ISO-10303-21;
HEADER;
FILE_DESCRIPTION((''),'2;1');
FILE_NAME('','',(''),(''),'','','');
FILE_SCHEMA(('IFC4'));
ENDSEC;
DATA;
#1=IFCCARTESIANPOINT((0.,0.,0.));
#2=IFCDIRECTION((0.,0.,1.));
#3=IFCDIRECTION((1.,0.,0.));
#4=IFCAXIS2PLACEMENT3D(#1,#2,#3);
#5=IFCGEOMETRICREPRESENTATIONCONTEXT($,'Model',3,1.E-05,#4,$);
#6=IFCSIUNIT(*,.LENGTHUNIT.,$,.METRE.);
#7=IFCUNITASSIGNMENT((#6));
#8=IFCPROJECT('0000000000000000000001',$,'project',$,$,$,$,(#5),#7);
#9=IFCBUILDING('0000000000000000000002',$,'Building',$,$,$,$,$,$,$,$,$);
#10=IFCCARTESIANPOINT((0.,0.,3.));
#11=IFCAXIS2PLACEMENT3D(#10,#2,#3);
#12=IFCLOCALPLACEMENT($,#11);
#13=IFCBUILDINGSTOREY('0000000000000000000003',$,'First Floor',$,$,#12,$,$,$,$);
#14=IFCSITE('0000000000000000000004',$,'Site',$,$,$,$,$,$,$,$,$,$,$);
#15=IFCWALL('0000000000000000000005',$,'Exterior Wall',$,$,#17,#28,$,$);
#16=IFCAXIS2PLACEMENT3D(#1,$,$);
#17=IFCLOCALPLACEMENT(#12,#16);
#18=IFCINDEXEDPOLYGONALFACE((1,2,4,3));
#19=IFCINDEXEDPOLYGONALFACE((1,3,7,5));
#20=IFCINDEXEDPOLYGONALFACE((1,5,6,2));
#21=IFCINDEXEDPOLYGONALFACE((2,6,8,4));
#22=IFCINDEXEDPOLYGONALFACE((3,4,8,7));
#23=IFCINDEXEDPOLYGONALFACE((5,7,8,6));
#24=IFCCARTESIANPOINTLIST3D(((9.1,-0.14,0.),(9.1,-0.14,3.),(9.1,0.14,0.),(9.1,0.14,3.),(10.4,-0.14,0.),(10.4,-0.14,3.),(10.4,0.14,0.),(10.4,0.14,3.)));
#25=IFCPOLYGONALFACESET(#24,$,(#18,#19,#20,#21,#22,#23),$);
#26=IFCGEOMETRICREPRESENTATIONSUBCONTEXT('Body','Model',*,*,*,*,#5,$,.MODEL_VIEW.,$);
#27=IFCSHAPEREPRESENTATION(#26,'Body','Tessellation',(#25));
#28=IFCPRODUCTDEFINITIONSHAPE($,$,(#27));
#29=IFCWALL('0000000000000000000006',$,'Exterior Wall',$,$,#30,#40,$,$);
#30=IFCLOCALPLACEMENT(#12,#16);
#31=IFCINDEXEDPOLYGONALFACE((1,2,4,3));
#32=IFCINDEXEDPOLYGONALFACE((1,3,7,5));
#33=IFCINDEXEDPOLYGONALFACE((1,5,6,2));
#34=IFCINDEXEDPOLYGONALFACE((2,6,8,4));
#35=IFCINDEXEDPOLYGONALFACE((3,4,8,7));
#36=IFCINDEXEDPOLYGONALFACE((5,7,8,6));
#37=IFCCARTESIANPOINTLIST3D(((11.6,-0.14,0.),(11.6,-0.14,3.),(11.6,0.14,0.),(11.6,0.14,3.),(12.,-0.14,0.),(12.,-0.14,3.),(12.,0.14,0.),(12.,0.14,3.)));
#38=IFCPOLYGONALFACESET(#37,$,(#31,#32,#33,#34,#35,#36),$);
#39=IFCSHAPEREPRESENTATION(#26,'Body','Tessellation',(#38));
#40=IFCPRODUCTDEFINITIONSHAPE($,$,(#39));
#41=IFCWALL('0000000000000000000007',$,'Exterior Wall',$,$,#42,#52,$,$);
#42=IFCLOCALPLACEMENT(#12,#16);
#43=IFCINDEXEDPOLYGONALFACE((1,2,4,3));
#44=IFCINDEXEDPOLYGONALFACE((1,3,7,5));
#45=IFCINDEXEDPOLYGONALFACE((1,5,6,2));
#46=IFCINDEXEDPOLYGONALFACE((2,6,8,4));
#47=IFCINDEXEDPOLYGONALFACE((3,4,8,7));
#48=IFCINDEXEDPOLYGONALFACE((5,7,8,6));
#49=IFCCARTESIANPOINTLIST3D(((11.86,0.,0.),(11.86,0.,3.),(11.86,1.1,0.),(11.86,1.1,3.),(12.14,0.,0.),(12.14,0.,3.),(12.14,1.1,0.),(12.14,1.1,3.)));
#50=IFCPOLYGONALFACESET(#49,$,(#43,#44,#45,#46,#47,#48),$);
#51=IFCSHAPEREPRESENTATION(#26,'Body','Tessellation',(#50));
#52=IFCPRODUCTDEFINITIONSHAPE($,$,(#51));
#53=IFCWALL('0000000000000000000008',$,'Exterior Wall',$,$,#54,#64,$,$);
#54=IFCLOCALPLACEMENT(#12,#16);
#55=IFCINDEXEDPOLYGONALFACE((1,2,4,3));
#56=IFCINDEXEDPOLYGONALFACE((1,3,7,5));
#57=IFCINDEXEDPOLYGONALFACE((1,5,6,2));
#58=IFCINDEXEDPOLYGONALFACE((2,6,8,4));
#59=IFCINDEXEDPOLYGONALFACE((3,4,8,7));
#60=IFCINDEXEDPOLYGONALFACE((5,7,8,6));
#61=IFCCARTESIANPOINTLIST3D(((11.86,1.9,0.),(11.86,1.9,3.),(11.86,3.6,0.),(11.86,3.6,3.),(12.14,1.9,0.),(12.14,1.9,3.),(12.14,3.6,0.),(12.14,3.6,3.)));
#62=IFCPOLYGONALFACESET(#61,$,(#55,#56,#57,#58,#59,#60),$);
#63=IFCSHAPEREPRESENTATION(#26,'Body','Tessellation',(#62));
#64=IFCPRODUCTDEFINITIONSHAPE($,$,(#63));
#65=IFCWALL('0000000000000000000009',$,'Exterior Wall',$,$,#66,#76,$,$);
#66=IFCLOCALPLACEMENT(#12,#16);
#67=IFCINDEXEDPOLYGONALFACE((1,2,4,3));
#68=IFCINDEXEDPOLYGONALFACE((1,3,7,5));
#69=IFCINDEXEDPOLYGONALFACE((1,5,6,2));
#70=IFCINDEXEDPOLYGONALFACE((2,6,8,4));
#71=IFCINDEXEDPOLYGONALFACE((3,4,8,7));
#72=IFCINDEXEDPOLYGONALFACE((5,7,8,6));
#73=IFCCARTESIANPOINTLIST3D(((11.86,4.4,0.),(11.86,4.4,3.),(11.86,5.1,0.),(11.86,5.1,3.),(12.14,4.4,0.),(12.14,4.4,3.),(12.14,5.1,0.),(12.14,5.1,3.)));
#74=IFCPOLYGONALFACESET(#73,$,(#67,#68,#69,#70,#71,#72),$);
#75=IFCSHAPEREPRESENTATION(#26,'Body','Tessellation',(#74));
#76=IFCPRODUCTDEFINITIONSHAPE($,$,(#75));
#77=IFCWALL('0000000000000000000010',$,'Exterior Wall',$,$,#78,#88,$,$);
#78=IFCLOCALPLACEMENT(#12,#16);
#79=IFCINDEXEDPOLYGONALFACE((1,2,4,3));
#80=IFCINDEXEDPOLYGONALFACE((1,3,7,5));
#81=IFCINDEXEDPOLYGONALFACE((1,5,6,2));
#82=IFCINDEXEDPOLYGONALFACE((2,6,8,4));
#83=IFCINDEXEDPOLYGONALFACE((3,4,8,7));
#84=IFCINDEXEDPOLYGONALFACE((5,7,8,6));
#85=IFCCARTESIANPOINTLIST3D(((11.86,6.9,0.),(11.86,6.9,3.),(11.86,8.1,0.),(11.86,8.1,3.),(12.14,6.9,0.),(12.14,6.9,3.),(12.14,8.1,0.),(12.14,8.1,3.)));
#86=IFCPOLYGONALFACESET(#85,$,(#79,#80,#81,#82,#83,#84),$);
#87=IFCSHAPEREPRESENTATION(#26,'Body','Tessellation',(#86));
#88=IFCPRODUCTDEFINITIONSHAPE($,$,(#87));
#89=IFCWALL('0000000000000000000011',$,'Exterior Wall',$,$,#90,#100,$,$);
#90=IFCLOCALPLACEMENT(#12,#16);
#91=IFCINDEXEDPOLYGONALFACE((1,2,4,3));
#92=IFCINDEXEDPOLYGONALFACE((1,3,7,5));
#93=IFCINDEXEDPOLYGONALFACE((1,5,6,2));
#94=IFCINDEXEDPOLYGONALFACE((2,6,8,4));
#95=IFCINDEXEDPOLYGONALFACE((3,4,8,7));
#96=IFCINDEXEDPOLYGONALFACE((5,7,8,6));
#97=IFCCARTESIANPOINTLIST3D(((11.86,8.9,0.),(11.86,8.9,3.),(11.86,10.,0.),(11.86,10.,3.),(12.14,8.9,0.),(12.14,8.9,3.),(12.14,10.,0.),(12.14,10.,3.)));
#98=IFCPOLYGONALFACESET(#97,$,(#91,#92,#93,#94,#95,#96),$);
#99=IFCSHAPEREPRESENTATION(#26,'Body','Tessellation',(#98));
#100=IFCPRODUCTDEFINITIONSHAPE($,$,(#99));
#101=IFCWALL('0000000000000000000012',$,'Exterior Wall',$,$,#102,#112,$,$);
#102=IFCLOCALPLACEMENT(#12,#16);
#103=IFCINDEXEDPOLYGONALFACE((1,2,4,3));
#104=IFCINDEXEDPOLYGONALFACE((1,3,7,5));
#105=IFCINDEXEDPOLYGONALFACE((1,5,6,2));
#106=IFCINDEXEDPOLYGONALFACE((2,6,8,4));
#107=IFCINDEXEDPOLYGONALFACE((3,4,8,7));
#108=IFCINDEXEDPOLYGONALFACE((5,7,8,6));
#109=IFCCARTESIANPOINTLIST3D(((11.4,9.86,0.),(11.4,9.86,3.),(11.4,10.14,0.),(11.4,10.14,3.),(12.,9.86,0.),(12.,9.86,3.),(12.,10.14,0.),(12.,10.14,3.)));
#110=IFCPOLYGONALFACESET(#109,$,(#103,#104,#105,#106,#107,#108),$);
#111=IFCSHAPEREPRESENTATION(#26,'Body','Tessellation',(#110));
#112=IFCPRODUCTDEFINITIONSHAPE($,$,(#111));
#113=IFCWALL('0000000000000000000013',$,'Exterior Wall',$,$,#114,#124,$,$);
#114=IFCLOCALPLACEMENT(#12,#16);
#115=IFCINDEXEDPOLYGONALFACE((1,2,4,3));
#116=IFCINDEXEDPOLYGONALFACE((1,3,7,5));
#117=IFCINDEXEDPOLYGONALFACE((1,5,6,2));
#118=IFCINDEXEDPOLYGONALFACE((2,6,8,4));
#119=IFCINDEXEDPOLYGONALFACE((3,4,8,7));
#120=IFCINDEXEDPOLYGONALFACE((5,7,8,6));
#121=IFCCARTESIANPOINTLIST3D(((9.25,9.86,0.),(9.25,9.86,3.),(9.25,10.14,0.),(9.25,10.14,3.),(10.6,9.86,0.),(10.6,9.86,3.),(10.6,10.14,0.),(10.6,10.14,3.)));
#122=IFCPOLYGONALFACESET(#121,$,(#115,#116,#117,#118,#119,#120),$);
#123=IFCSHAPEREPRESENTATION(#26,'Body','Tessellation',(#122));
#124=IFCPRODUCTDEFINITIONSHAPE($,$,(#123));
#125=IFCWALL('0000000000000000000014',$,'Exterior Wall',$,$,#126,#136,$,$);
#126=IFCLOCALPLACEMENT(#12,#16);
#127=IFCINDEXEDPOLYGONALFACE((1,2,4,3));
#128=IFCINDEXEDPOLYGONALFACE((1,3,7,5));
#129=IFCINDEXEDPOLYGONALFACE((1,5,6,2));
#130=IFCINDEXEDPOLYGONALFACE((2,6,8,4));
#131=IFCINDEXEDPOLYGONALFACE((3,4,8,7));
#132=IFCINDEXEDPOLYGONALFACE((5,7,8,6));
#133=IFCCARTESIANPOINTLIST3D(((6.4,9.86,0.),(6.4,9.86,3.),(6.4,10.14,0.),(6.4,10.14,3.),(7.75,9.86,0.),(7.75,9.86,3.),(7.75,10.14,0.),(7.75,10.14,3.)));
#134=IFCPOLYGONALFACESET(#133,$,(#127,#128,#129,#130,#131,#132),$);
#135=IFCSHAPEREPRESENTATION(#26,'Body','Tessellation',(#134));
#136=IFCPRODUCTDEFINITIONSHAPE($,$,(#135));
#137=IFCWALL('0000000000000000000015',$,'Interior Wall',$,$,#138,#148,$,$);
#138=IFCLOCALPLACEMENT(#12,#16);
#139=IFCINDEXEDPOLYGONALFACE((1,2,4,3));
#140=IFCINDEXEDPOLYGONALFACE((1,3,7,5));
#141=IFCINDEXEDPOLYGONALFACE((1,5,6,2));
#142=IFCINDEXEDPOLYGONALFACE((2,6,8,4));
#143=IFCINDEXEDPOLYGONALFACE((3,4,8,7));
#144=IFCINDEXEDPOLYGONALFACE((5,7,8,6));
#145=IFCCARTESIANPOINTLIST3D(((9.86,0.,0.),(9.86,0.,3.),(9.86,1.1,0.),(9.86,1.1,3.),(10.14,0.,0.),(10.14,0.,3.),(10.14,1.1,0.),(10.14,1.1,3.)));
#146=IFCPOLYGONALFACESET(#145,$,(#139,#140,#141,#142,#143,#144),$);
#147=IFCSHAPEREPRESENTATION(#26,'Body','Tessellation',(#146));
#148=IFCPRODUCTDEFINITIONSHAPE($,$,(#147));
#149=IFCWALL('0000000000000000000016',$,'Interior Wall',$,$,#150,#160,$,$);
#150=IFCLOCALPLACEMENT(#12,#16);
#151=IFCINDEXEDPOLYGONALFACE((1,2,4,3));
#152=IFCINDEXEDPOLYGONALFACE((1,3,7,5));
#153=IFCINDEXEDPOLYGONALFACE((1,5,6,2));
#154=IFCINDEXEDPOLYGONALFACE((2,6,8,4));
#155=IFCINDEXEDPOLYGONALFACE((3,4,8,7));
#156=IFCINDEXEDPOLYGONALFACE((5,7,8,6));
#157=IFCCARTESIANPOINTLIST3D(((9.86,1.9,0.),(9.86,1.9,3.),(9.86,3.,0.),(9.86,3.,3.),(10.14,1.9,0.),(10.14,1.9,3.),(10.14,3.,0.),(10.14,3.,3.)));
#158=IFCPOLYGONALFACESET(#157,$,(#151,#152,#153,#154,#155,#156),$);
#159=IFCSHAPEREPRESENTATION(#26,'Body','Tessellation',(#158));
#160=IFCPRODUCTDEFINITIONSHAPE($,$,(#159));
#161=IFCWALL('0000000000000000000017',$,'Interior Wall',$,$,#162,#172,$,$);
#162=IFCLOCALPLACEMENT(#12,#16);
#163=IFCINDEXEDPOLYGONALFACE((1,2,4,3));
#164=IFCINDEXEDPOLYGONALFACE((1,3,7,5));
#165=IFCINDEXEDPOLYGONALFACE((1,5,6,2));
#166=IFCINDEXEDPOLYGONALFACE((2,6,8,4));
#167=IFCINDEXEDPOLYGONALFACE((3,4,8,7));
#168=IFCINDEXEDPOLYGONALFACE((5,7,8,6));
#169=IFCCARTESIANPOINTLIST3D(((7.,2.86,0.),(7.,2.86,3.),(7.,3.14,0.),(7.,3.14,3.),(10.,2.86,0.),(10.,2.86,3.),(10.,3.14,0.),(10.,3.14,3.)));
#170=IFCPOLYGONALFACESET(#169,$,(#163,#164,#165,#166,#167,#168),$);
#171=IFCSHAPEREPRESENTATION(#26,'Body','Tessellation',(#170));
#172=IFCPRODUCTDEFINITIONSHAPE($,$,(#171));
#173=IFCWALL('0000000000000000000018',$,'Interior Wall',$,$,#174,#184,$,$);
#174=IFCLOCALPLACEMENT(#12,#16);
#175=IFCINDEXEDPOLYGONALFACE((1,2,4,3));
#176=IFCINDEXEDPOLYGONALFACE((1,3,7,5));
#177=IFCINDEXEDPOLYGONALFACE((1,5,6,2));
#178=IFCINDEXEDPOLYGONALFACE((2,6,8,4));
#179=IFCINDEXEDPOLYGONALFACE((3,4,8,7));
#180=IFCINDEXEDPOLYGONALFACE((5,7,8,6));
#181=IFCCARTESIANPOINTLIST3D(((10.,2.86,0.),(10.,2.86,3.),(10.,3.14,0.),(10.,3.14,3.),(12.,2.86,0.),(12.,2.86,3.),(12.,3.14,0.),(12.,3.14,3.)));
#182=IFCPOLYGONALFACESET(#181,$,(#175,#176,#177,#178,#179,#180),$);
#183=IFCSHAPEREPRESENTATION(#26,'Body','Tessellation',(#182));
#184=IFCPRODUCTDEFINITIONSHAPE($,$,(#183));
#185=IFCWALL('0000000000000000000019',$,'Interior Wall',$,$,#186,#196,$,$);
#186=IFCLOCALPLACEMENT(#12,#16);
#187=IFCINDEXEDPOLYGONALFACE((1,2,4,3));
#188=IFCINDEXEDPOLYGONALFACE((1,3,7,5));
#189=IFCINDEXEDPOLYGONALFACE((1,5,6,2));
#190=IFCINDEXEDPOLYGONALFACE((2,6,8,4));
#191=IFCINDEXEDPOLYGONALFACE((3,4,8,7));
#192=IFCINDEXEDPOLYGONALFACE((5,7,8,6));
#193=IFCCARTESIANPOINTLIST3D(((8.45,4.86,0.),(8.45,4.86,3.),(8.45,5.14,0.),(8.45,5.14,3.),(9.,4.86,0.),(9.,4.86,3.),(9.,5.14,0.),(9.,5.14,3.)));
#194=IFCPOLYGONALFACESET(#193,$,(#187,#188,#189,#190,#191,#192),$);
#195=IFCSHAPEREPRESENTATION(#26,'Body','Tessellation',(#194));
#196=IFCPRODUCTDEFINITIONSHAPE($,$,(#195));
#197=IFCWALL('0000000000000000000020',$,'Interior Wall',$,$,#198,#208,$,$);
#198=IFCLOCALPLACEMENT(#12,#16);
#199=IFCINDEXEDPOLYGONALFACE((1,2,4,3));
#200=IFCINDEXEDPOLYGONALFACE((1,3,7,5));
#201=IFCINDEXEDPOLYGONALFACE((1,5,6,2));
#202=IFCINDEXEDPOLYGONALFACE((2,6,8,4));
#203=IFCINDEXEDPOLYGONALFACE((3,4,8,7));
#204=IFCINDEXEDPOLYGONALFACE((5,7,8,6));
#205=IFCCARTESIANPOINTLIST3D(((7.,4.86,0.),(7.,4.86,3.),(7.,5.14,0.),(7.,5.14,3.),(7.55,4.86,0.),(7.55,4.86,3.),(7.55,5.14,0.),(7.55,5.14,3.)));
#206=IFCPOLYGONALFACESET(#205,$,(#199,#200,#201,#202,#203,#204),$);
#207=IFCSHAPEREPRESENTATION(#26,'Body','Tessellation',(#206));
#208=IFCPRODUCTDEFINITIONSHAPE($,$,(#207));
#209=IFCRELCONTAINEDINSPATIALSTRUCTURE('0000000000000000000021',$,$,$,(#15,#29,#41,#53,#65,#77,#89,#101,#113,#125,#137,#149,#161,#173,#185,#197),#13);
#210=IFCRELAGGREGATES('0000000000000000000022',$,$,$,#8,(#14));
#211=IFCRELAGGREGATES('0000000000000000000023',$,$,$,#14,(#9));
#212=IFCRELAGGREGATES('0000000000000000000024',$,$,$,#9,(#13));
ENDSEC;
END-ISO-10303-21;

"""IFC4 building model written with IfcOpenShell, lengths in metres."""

from ifc_helpers import new_model, si_unit, frame, origin_with_axes, place, context, subcontext, project, spatial, indexed_curve, outline, extrude, element, save


model = new_model("IFC4")

# Units and contexts
model_context = context("Model", 3, precision=1e-05, world=origin_with_axes())
body_context = subcontext(model_context, "Body", "Model", "MODEL_VIEW")
ifc_project = project(units=[si_unit("LENGTHUNIT", "METRE")], contexts=[model_context])

# Site, building, storey
site = spatial("IfcSite", under=ifc_project, Name="Site")
building = spatial("IfcBuilding", under=site, Name="Building")
storey_placement = place(None, frame((0.0, 0.0, 3.0), z_axis=(0.0, 0.0, 1.0), x_axis=(1.0, 0.0, 0.0)))
storey = spatial("IfcBuildingStorey", under=building, at=storey_placement, Name="First Floor")

# Walls
wall_1_placement = place(storey_placement, frame((9.1, 0.0, 0.0), z_axis=(0.0, 0.0, 1.0), x_axis=(1.0, 0.0, 0.0)))
element("IfcWall", 1, at=wall_1_placement, inside=storey, Name="Exterior Wall", context=body_context, shape_type="SweptSolid", body=[
    extrude(outline(indexed_curve([(0.0, 0.0), (0.0, 0.28), (1.3, 0.28), (1.3, 0.0), (0.0, 0.0)], self_intersect=False)), frame((0.0, -0.14, 0.0), z_axis=(0.0, 0.0, 1.0), x_axis=(1.0, 0.0, 0.0)), (0.0, 0.0, 1.0), 3.0),
])
wall_2_placement = place(storey_placement, frame((11.6, 0.0, 0.0), z_axis=(0.0, 0.0, 1.0), x_axis=(1.0, 0.0, 0.0)))
element("IfcWall", 2, at=wall_2_placement, inside=storey, Name="Exterior Wall", context=body_context, shape_type="SweptSolid", body=[
    extrude(outline(indexed_curve([(0.0, 0.0), (0.0, 0.28), (0.4, 0.28), (0.4, 0.0), (0.0, 0.0)], self_intersect=False)), frame((0.0, -0.14, 0.0), z_axis=(0.0, 0.0, 1.0), x_axis=(1.0, 0.0, 0.0)), (0.0, 0.0, 1.0), 3.0),
])
wall_3_placement = place(storey_placement, frame((12.0, 0.0, 0.0), z_axis=(0.0, 0.0, 1.0), x_axis=(0.0, 1.0, 0.0)))
element("IfcWall", 3, at=wall_3_placement, inside=storey, Name="Exterior Wall", context=body_context, shape_type="SweptSolid", body=[
    extrude(outline(indexed_curve([(0.0, 0.0), (0.0, 0.28), (1.1, 0.28), (1.1, 0.0), (0.0, 0.0)], self_intersect=False)), frame((0.0, -0.14, 0.0), z_axis=(0.0, 0.0, 1.0), x_axis=(1.0, 0.0, 0.0)), (0.0, 0.0, 1.0), 3.0),
])
wall_4_placement = place(storey_placement, frame((12.0, 1.9, 0.0), z_axis=(0.0, 0.0, 1.0), x_axis=(0.0, 1.0, 0.0)))
element("IfcWall", 4, at=wall_4_placement, inside=storey, Name="Exterior Wall", context=body_context, shape_type="SweptSolid", body=[
    extrude(outline(indexed_curve([(0.0, 0.0), (0.0, 0.28), (1.7, 0.28), (1.7, 0.0), (0.0, 0.0)], self_intersect=False)), frame((0.0, -0.14, 0.0), z_axis=(0.0, 0.0, 1.0), x_axis=(1.0, 0.0, 0.0)), (0.0, 0.0, 1.0), 3.0),
])
wall_5_placement = place(storey_placement, frame((12.0, 4.4, 0.0), z_axis=(0.0, 0.0, 1.0), x_axis=(0.0, 1.0, 0.0)))
element("IfcWall", 5, at=wall_5_placement, inside=storey, Name="Exterior Wall", context=body_context, shape_type="SweptSolid", body=[
    extrude(outline(indexed_curve([(0.0, 0.0), (0.0, 0.28), (0.7, 0.28), (0.7, 0.0), (0.0, 0.0)], self_intersect=False)), frame((0.0, -0.14, 0.0), z_axis=(0.0, 0.0, 1.0), x_axis=(1.0, 0.0, 0.0)), (0.0, 0.0, 1.0), 3.0),
])
wall_6_placement = place(storey_placement, frame((12.0, 6.9, 0.0), z_axis=(0.0, 0.0, 1.0), x_axis=(0.0, 1.0, 0.0)))
element("IfcWall", 6, at=wall_6_placement, inside=storey, Name="Exterior Wall", context=body_context, shape_type="SweptSolid", body=[
    extrude(outline(indexed_curve([(0.0, 0.0), (0.0, 0.28), (1.2, 0.28), (1.2, 0.0), (0.0, 0.0)], self_intersect=False)), frame((0.0, -0.14, 0.0), z_axis=(0.0, 0.0, 1.0), x_axis=(1.0, 0.0, 0.0)), (0.0, 0.0, 1.0), 3.0),
])
wall_7_placement = place(storey_placement, frame((12.0, 8.9, 0.0), z_axis=(0.0, 0.0, 1.0), x_axis=(0.0, 1.0, 0.0)))
element("IfcWall", 7, at=wall_7_placement, inside=storey, Name="Exterior Wall", context=body_context, shape_type="SweptSolid", body=[
    extrude(outline(indexed_curve([(0.0, 0.0), (0.0, 0.28), (1.1, 0.28), (1.1, 0.0), (0.0, 0.0)], self_intersect=False)), frame((0.0, -0.14, 0.0), z_axis=(0.0, 0.0, 1.0), x_axis=(1.0, 0.0, 0.0)), (0.0, 0.0, 1.0), 3.0),
])
wall_8_placement = place(storey_placement, frame((12.0, 10.0, 0.0), z_axis=(0.0, 0.0, 1.0), x_axis=(-1.0, 0.0, 0.0)))
element("IfcWall", 8, at=wall_8_placement, inside=storey, Name="Exterior Wall", context=body_context, shape_type="SweptSolid", body=[
    extrude(outline(indexed_curve([(0.0, 0.0), (0.0, 0.28), (0.6, 0.28), (0.6, 0.0), (0.0, 0.0)], self_intersect=False)), frame((0.0, -0.14, 0.0), z_axis=(0.0, 0.0, 1.0), x_axis=(1.0, 0.0, 0.0)), (0.0, 0.0, 1.0), 3.0),
])
for number, where, z_axis, x_axis, name in (
    (9, (10.6, 10.0, 0.0), (0.0, 0.0, 1.0), (-1.0, 0.0, 0.0), "Exterior Wall"),
    (10, (7.75, 10.0, 0.0), (0.0, 0.0, 1.0), (-1.0, 0.0, 0.0), "Exterior Wall"),
):
    element("IfcWall", number, at=place(storey_placement, frame(where, z_axis=z_axis, x_axis=x_axis)), inside=storey, Name=name, context=body_context, shape_type="SweptSolid", body=[
        extrude(outline(indexed_curve([(0.0, 0.0), (0.0, 0.28), (1.35, 0.28), (1.35, 0.0), (0.0, 0.0)], self_intersect=False)), frame((0.0, -0.14, 0.0), z_axis=(0.0, 0.0, 1.0), x_axis=(1.0, 0.0, 0.0)), (0.0, 0.0, 1.0), 3.0),
    ])
for number, where, z_axis, x_axis, name in (
    (11, (10.0, 0.0, 0.0), (0.0, 0.0, 1.0), (0.0, 1.0, 0.0), "Interior Wall"),
    (12, (10.0, 1.9, 0.0), (0.0, 0.0, 1.0), (0.0, 1.0, 0.0), "Interior Wall"),
):
    element("IfcWall", number, at=place(storey_placement, frame(where, z_axis=z_axis, x_axis=x_axis)), inside=storey, Name=name, context=body_context, shape_type="SweptSolid", body=[
        extrude(outline(indexed_curve([(0.0, 0.0), (0.0, 0.28), (1.1, 0.28), (1.1, 0.0), (0.0, 0.0)], self_intersect=False)), frame((0.0, -0.14, 0.0), z_axis=(0.0, 0.0, 1.0), x_axis=(1.0, 0.0, 0.0)), (0.0, 0.0, 1.0), 3.0),
    ])
wall_9_placement = place(storey_placement, frame((10.0, 3.0, 0.0), z_axis=(0.0, 0.0, 1.0), x_axis=(-1.0, 0.0, 0.0)))
element("IfcWall", 13, at=wall_9_placement, inside=storey, Name="Interior Wall", context=body_context, shape_type="SweptSolid", body=[
    extrude(outline(indexed_curve([(0.0, 0.0), (0.0, 0.28), (3.0, 0.28), (3.0, 0.0), (0.0, 0.0)], self_intersect=False)), frame((0.0, -0.14, 0.0), z_axis=(0.0, 0.0, 1.0), x_axis=(1.0, 0.0, 0.0)), (0.0, 0.0, 1.0), 3.0),
])
wall_10_placement = place(storey_placement, frame((12.0, 3.0, 0.0), z_axis=(0.0, 0.0, 1.0), x_axis=(-1.0, 0.0, 0.0)))
element("IfcWall", 14, at=wall_10_placement, inside=storey, Name="Interior Wall", context=body_context, shape_type="SweptSolid", body=[
    extrude(outline(indexed_curve([(0.0, 0.0), (0.0, 0.28), (2.0, 0.28), (2.0, 0.0), (0.0, 0.0)], self_intersect=False)), frame((0.0, -0.14, 0.0), z_axis=(0.0, 0.0, 1.0), x_axis=(1.0, 0.0, 0.0)), (0.0, 0.0, 1.0), 3.0),
])
wall_11_placement = place(storey_placement, frame((9.0, 5.0, 0.0), z_axis=(0.0, 0.0, 1.0), x_axis=(-1.0, 0.0, 0.0)))
element("IfcWall", 15, at=wall_11_placement, inside=storey, Name="Interior Wall", context=body_context, shape_type="SweptSolid", body=[
    extrude(outline(indexed_curve([(0.0, 0.0), (0.0, 0.28), (0.55, 0.28), (0.55, 0.0), (0.0, 0.0)], self_intersect=False)), frame((0.0, -0.14, 0.0), z_axis=(0.0, 0.0, 1.0), x_axis=(1.0, 0.0, 0.0)), (0.0, 0.0, 1.0), 3.0),
])
wall_12_placement = place(storey_placement, frame((7.55, 5.0, 0.0), z_axis=(0.0, 0.0, 1.0), x_axis=(-1.0, 0.0, 0.0)))
element("IfcWall", 16, at=wall_12_placement, inside=storey, Name="Interior Wall", context=body_context, shape_type="SweptSolid", body=[
    extrude(outline(indexed_curve([(0.0, 0.0), (0.0, 0.28), (0.55, 0.28), (0.55, 0.0), (0.0, 0.0)], self_intersect=False)), frame((0.0, -0.14, 0.0), z_axis=(0.0, 0.0, 1.0), x_axis=(1.0, 0.0, 0.0)), (0.0, 0.0, 1.0), 3.0),
])

save(model, "model.ifc")
